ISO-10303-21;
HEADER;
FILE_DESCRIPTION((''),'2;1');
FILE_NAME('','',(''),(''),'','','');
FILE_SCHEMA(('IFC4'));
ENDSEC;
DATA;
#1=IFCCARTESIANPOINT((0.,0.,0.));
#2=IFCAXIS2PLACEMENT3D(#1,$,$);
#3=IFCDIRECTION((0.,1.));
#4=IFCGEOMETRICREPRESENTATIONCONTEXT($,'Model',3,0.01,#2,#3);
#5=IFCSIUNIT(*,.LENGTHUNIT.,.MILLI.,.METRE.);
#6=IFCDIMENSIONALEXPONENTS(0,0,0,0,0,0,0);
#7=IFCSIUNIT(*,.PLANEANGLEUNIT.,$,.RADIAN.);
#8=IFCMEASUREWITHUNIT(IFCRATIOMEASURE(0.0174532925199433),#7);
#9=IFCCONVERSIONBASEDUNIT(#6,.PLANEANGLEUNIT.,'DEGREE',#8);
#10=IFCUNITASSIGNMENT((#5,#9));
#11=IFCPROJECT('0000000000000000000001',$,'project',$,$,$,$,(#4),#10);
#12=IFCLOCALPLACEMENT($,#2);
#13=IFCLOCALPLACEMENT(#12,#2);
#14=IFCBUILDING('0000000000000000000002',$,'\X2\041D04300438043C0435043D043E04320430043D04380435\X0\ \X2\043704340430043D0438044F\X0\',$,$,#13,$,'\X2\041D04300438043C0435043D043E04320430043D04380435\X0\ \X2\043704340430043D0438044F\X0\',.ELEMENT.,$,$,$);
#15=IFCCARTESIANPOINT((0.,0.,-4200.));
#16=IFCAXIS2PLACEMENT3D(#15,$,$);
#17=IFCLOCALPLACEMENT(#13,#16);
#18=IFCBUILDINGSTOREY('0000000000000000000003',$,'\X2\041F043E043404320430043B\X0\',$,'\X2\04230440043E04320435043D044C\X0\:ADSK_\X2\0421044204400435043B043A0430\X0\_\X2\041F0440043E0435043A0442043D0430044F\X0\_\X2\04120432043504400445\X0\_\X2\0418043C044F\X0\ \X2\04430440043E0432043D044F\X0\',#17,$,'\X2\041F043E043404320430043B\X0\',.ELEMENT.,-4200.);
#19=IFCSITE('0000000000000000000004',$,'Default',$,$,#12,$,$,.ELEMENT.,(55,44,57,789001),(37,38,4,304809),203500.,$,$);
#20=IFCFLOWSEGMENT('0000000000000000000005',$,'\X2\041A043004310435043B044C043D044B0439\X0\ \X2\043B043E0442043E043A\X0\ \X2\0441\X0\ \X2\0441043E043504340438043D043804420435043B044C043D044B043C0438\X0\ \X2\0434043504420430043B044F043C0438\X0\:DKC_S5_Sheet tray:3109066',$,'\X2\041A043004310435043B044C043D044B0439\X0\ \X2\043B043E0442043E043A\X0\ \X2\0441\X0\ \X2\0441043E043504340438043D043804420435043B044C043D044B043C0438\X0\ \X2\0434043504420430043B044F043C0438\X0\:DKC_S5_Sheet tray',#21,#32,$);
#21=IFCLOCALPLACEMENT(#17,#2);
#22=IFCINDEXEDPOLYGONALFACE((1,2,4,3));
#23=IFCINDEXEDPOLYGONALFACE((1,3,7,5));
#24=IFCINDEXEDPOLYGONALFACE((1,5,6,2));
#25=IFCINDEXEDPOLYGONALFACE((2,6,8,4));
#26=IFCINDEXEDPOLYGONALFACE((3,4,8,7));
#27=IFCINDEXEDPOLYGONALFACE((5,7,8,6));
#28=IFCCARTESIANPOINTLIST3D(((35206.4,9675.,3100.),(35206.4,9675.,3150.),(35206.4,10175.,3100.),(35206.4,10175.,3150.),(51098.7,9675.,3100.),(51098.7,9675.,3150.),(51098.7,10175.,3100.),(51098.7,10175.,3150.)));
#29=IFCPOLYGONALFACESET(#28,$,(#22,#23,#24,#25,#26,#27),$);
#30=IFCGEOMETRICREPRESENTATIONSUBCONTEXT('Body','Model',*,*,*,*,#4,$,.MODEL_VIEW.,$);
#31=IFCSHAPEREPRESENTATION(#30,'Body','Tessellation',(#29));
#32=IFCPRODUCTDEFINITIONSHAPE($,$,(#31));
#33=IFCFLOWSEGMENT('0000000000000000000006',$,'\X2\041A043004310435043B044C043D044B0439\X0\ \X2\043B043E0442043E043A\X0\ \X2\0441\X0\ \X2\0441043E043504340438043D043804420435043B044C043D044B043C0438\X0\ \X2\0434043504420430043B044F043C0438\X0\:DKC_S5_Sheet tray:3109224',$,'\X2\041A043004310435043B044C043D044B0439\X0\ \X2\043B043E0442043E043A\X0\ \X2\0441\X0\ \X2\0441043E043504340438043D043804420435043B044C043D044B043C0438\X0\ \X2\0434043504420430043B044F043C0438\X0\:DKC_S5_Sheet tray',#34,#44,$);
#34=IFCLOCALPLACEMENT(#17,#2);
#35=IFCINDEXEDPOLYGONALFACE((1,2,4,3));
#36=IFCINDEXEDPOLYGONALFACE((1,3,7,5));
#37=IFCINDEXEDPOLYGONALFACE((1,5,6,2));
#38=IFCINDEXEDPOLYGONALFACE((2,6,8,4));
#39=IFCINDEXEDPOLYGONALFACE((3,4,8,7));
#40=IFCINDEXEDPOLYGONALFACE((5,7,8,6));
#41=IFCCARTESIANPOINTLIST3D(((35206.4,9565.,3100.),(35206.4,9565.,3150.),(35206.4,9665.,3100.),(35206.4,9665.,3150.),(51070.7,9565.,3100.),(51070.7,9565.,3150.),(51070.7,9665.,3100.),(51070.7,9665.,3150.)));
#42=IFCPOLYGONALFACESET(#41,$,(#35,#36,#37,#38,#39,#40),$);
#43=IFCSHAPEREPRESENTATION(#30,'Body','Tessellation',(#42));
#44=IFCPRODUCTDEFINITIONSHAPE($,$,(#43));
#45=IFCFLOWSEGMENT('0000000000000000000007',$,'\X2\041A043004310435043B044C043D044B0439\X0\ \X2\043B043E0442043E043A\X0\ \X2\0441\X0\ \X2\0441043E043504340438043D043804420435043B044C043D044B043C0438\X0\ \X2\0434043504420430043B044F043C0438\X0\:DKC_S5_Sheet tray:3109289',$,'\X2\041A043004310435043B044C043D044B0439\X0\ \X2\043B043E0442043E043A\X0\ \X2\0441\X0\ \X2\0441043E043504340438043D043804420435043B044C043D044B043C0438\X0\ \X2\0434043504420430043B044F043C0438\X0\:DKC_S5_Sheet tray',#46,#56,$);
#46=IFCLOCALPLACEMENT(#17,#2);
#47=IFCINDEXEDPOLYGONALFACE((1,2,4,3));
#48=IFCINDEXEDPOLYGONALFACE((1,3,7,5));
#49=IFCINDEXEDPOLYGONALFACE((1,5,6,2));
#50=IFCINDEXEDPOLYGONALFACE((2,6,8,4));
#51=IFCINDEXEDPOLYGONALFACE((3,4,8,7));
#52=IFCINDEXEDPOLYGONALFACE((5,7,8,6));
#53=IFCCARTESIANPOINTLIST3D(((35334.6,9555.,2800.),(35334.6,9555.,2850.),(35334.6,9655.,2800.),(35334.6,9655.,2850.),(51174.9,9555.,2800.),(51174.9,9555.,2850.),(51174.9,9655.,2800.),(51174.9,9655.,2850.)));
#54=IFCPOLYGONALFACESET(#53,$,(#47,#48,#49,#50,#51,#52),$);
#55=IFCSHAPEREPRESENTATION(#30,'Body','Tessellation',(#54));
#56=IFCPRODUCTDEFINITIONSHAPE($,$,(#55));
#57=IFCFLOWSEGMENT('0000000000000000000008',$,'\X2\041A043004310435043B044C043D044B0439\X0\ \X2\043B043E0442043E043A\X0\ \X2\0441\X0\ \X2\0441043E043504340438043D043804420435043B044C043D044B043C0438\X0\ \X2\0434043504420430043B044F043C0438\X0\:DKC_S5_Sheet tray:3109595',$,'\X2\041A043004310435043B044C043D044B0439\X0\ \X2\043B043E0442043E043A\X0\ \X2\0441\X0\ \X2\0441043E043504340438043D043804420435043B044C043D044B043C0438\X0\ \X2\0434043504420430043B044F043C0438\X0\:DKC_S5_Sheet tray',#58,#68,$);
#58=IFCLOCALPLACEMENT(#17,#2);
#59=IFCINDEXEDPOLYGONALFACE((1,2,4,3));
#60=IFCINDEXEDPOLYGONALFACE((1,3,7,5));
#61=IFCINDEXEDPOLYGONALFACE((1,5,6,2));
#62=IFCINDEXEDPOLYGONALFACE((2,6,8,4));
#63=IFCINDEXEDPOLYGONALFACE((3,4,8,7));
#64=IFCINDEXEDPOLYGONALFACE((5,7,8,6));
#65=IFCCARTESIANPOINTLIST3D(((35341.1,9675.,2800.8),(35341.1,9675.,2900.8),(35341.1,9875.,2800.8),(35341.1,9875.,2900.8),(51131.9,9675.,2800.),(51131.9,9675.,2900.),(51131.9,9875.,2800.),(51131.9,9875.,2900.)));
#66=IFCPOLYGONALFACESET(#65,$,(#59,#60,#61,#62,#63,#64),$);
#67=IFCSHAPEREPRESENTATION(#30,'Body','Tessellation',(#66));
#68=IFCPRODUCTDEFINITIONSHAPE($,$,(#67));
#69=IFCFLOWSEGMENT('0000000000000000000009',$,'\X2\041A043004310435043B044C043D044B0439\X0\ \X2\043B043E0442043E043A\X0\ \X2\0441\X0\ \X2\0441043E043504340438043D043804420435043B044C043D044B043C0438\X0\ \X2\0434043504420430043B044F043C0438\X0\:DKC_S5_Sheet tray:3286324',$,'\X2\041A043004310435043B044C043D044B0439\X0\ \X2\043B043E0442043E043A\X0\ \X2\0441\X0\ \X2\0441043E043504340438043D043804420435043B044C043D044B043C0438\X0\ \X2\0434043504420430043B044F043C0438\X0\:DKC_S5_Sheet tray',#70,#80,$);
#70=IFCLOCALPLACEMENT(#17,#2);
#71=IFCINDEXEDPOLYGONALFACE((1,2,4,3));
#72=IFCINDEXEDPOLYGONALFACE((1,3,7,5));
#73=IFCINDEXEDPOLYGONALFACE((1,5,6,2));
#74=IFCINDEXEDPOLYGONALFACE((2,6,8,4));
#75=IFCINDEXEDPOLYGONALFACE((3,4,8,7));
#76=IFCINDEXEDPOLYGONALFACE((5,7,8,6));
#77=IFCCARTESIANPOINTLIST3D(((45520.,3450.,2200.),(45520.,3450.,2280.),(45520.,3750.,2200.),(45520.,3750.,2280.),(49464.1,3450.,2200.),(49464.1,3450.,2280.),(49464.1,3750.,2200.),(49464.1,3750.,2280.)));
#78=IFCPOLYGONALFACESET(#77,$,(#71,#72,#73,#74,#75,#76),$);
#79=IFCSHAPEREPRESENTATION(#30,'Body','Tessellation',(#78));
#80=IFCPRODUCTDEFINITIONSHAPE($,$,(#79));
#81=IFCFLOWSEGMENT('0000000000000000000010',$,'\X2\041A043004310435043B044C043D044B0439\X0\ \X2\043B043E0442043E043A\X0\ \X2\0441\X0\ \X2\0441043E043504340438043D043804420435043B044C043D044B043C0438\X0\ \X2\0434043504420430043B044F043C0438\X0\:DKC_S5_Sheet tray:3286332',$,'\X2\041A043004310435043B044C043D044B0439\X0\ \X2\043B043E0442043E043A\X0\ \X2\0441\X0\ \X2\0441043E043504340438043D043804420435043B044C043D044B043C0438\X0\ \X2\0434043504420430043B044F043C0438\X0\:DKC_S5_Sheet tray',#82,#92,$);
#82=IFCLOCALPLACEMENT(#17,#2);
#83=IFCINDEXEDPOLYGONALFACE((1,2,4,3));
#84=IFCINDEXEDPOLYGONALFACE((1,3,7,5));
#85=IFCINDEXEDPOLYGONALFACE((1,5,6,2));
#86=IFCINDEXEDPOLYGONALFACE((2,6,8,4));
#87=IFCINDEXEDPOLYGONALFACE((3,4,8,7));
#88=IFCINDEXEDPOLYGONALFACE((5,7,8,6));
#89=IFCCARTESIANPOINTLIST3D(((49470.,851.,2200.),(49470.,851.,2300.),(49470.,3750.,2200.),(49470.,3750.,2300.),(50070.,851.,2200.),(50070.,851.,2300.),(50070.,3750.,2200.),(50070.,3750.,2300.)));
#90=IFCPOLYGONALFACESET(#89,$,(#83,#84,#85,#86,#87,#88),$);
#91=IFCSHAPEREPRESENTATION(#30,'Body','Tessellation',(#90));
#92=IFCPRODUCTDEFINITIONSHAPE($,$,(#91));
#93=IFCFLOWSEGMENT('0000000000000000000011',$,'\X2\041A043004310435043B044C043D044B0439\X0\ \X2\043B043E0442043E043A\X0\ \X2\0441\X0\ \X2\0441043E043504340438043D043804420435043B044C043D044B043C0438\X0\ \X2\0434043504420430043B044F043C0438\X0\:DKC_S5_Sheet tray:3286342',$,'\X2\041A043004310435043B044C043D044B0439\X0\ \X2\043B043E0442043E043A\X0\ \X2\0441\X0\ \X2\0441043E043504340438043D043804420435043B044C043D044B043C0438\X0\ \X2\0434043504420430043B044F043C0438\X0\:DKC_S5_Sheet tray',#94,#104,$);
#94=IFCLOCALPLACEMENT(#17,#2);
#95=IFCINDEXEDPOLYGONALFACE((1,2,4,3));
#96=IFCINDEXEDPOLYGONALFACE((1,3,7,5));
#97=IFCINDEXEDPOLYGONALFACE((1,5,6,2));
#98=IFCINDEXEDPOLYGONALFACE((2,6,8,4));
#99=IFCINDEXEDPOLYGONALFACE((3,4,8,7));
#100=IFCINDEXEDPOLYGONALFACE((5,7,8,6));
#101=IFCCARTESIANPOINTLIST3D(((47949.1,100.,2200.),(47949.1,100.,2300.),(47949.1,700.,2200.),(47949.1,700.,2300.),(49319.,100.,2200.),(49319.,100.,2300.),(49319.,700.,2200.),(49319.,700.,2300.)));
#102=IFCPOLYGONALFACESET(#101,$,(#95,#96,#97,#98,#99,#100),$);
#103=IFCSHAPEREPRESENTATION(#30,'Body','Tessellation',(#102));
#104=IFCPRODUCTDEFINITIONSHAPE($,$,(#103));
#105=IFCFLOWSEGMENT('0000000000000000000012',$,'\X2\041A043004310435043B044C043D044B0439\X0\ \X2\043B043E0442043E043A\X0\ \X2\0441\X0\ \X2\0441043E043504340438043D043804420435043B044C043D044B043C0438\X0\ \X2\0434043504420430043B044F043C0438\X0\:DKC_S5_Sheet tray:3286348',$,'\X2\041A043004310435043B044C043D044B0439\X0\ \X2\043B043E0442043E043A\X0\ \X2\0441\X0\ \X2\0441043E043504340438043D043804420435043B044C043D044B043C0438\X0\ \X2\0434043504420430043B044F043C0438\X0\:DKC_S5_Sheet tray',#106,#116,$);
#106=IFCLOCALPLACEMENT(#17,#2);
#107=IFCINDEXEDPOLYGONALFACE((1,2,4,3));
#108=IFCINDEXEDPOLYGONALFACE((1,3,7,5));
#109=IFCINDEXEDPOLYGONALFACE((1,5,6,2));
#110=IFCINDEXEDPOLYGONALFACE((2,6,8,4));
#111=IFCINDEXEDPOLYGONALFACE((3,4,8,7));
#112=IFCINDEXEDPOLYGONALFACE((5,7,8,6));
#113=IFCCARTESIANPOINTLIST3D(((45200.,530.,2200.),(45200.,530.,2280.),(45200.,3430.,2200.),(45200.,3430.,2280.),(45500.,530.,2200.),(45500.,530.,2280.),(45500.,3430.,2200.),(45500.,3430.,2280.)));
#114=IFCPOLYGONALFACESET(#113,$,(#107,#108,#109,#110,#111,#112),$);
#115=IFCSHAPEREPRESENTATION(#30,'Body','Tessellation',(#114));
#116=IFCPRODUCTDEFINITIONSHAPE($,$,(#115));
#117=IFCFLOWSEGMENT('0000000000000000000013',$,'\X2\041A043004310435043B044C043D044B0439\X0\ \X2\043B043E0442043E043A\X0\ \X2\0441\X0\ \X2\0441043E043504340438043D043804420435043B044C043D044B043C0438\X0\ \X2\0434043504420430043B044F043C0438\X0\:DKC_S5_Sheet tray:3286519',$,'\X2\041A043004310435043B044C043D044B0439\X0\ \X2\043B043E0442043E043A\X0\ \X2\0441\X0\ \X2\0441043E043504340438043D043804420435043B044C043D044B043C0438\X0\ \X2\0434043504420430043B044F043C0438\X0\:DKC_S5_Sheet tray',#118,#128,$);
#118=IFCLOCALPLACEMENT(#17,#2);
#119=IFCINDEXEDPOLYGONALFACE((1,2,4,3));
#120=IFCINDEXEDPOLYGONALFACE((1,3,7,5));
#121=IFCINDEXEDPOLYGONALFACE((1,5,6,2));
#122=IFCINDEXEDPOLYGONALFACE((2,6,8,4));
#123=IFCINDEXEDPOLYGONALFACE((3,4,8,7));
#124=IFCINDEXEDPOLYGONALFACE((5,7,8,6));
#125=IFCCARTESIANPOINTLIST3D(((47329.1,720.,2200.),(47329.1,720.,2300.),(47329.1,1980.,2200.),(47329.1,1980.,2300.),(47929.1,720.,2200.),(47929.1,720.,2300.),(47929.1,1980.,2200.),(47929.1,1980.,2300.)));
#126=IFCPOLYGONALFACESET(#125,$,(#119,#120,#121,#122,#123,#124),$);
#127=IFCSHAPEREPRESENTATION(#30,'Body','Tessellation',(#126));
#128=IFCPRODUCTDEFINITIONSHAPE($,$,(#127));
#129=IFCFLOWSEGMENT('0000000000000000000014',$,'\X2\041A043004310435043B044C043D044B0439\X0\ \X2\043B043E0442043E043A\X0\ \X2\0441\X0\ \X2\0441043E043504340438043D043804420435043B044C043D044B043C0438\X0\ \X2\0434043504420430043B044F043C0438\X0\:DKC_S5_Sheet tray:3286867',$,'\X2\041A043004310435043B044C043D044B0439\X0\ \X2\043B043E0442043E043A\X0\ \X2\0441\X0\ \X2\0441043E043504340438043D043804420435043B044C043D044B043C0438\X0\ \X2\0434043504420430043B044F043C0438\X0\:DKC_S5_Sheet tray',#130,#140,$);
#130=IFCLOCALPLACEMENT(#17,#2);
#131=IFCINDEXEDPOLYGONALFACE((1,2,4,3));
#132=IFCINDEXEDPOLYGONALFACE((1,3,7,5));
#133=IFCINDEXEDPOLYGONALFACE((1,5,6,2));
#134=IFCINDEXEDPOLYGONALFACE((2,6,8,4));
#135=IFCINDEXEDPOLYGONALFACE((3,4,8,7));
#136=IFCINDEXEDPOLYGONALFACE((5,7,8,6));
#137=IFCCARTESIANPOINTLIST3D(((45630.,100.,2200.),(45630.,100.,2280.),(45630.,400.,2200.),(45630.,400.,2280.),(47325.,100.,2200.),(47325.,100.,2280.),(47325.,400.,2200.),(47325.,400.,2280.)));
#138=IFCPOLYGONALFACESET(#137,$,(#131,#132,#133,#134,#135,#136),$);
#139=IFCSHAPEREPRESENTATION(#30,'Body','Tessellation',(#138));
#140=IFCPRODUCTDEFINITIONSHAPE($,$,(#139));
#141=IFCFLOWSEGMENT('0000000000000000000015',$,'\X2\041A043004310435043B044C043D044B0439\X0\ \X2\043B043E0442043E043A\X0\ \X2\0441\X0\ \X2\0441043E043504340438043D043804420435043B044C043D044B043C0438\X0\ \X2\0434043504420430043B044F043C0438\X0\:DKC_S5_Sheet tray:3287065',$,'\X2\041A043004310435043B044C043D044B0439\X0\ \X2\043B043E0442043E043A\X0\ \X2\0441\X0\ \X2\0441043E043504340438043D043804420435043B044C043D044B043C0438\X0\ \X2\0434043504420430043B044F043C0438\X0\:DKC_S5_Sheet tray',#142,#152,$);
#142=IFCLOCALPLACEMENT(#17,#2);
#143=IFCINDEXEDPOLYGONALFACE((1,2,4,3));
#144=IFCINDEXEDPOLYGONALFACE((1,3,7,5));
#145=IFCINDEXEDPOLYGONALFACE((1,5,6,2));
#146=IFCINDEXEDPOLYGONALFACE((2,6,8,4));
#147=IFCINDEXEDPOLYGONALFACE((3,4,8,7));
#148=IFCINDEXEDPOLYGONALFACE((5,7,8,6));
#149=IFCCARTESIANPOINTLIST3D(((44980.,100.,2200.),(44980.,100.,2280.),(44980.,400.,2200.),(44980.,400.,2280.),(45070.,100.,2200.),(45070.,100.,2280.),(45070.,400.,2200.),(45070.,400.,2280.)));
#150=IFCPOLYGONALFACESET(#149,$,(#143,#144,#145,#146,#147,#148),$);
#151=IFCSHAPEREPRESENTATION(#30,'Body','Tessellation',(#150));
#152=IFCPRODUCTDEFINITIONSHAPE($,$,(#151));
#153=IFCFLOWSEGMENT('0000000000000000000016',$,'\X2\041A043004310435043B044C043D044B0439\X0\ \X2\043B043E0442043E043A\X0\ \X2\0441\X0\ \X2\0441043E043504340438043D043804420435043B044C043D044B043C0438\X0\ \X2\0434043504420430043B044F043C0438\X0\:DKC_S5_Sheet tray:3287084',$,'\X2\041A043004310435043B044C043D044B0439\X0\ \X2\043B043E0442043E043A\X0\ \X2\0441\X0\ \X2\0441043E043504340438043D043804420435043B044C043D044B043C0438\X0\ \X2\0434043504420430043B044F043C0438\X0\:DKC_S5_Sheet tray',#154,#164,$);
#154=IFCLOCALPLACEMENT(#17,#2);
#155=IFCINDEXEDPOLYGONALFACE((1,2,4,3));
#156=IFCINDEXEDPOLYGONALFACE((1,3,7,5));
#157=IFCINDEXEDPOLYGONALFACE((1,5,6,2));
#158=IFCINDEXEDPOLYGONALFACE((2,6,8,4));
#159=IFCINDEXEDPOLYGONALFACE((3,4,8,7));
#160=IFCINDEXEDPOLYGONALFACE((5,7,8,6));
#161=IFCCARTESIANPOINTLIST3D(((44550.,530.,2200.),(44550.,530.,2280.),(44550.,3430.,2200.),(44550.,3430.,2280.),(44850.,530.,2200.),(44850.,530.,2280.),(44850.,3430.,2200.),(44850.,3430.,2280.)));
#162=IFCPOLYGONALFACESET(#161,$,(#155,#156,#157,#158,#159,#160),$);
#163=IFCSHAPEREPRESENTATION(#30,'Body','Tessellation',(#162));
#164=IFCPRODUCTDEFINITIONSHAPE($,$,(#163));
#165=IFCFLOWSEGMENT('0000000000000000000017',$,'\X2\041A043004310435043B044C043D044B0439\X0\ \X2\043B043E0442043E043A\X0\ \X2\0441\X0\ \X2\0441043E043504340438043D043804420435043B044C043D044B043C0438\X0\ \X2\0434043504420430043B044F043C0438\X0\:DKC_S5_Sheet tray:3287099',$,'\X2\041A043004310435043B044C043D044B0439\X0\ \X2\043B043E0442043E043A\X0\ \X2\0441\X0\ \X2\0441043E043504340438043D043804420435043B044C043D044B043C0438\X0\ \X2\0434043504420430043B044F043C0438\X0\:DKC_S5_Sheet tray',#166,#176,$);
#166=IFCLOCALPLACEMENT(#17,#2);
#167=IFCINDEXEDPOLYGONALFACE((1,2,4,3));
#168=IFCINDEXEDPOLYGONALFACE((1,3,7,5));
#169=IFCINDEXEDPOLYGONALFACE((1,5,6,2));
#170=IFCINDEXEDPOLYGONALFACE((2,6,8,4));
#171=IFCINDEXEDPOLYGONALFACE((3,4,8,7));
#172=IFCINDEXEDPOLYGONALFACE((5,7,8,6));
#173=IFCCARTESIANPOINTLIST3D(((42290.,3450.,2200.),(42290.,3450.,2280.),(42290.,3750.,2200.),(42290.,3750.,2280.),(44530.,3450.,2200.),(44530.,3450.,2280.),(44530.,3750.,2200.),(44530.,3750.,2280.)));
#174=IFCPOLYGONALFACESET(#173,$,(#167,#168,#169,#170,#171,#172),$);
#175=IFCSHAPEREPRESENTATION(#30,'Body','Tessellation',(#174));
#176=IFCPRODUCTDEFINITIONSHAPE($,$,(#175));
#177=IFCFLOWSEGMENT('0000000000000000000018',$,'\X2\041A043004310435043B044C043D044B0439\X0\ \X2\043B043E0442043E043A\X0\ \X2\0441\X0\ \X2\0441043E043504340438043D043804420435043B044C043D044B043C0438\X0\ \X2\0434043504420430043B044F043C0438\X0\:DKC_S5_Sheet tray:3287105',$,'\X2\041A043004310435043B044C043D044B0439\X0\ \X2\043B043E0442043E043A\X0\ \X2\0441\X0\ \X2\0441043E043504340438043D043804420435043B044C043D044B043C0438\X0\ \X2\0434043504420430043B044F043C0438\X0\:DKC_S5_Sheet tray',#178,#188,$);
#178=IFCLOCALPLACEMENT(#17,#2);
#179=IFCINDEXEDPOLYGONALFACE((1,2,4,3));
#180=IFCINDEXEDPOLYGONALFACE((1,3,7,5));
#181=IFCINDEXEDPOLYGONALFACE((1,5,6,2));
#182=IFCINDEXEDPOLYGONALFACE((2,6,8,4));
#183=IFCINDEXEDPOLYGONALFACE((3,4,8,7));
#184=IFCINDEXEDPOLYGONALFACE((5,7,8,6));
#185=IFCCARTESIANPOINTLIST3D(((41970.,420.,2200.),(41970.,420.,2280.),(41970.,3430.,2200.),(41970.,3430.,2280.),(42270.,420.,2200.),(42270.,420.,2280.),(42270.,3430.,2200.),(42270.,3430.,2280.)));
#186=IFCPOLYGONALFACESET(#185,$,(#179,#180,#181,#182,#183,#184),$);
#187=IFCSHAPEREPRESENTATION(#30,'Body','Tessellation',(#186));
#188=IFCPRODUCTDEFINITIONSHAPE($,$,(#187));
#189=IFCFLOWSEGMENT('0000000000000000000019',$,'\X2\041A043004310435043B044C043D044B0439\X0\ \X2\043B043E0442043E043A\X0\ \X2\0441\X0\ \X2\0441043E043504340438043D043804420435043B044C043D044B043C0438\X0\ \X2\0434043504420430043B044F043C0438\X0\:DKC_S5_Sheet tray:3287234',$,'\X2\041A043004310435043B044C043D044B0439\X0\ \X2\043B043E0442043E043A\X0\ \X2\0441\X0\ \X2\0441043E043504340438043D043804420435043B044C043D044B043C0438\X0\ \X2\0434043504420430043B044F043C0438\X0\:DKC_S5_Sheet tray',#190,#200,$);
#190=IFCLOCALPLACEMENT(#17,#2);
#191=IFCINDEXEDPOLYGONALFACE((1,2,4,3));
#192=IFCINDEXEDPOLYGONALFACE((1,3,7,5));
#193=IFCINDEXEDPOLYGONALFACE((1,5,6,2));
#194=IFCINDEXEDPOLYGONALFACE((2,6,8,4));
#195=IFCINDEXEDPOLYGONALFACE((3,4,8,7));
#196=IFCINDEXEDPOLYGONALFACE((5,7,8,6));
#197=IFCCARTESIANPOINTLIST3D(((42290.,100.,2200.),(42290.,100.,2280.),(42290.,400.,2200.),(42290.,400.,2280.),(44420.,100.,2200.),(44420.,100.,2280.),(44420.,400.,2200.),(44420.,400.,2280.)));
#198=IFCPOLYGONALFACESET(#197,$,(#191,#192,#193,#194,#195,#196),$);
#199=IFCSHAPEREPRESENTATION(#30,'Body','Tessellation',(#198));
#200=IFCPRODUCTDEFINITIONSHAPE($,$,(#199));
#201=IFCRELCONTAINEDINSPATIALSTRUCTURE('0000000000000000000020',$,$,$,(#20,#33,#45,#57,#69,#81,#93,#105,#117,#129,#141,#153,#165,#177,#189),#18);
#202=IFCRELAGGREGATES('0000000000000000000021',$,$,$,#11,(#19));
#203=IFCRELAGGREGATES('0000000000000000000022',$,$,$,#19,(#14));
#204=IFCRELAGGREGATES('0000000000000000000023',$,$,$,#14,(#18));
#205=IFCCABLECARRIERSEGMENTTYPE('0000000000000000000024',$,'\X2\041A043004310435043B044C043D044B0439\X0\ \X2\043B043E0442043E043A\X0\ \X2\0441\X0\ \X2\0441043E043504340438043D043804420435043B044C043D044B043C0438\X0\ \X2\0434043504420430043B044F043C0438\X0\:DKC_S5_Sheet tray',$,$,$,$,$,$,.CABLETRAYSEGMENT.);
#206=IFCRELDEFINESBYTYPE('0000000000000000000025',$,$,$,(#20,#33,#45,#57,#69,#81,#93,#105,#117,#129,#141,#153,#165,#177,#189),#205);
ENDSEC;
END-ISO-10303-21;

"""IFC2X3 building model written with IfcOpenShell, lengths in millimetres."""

from ifc_helpers import new_model, entity, si_unit, converted_unit, direction, frame, frame_2d, origin, origin_2d_with_axis, place, context, subcontext, project, spatial, rectangle, extrude, type_object, element, save


model = new_model("IFC2X3")

# Units and contexts
model_context = context("Model", 3, precision=0.01, world=origin(), true_north=direction((0.0, 1.0)))
body_context = subcontext(model_context, "Body", "Model", "MODEL_VIEW")
ifc_project = project(units=[si_unit("LENGTHUNIT", "METRE", prefix="MILLI"), converted_unit("PLANEANGLEUNIT", "DEGREE", entity("IfcRatioMeasure", 0.0174532925199433), si_unit("PLANEANGLEUNIT", "RADIAN"), dimensions=[0, 0, 0, 0, 0, 0, 0])], contexts=[model_context])

# Site, building, storey
site_placement = place(None, frame((0.0, 0.0, 0.0)))
site = spatial("IfcSite", under=ifc_project, at=site_placement, Name="Default", CompositionType="ELEMENT", RefLatitude=(55, 44, 57, 789001), RefLongitude=(37, 38, 4, 304809), RefElevation=203500.0)
building_placement = place(site_placement, origin())
building = spatial("IfcBuilding", under=site, at=building_placement, Name="Наименование здания", LongName="Наименование здания", CompositionType="ELEMENT")
storey_placement = place(building_placement, frame((0.0, 0.0, -4200.0)))
storey = spatial("IfcBuildingStorey", under=building, at=storey_placement, Name="Подвал", ObjectType="Уровень:ADSK_Стрелка_Проектная_Вверх_Имя уровня", LongName="Подвал", CompositionType="ELEMENT", Elevation=-4200.0)

# Flow segments
cable_carrier_segment_type_1 = type_object("IfcCableCarrierSegmentType", Name="Кабельный лоток с соединительными деталями:DKC_S5_Sheet tray", PredefinedType="CABLETRAYSEGMENT")
flow_segment_1_placement = place(storey_placement, frame((35206.4, 9675.0, 3100.0)))
element("IfcFlowSegment", 1, at=flow_segment_1_placement, inside=storey, type_object=cable_carrier_segment_type_1, Name="Кабельный лоток с соединительными деталями:DKC_S5_Sheet tray:3109066", ObjectType="Кабельный лоток с соединительными деталями:DKC_S5_Sheet tray", context=body_context, shape_type="SweptSolid", body=[
    extrude(rectangle(XDim=15892.3, YDim=500.0, at=frame_2d((0.0, 0.0), x_axis=(1.0, 0.0))), frame((7946.1, 250.0, 0.0), z_axis=(0.0, 0.0, 1.0), x_axis=(-1.0, 0.0, 0.0)), (0.0, 0.0, 1.0), 50.0),
])
flow_segment_2_placement = place(storey_placement, frame((35206.4, 9565.0, 3100.0)))
element("IfcFlowSegment", 2, at=flow_segment_2_placement, inside=storey, type_object=cable_carrier_segment_type_1, Name="Кабельный лоток с соединительными деталями:DKC_S5_Sheet tray:3109224", ObjectType="Кабельный лоток с соединительными деталями:DKC_S5_Sheet tray", context=body_context, shape_type="SweptSolid", body=[
    extrude(rectangle(XDim=15864.3, YDim=100.0, at=frame_2d((0.0, 0.0), x_axis=(1.0, 0.0))), frame((7932.2, 50.0, 0.0), z_axis=(0.0, 0.0, 1.0), x_axis=(-1.0, 0.0, 0.0)), (0.0, 0.0, 1.0), 50.0),
])
flow_segment_3_placement = place(storey_placement, frame((35334.6, 9555.0, 2800.0)))
element("IfcFlowSegment", 3, at=flow_segment_3_placement, inside=storey, type_object=cable_carrier_segment_type_1, Name="Кабельный лоток с соединительными деталями:DKC_S5_Sheet tray:3109289", ObjectType="Кабельный лоток с соединительными деталями:DKC_S5_Sheet tray", context=body_context, shape_type="SweptSolid", body=[
    extrude(rectangle(XDim=15840.3, YDim=100.0, at=frame_2d((0.0, 0.0), x_axis=(1.0, 0.0))), frame((7920.1, 50.0, 0.0)), (0.0, 0.0, 1.0), 50.0),
])
flow_segment_4_placement = place(storey_placement, frame((35341.1, 9675.0, 2800.0)))
element("IfcFlowSegment", 4, at=flow_segment_4_placement, inside=storey, type_object=cable_carrier_segment_type_1, Name="Кабельный лоток с соединительными деталями:DKC_S5_Sheet tray:3109595", ObjectType="Кабельный лоток с соединительными деталями:DKC_S5_Sheet tray", context=body_context, shape_type="SweptSolid", body=[
    extrude(rectangle(XDim=200.0, YDim=15790.8, at=frame_2d((0.0, 0.0), x_axis=(0.0, 1.0))), frame((7895.4, 100.0, 0.4), z_axis=(0.00005, 0.000146, 1.0), x_axis=(1.0, 0.0, -0.00005)), (0.0, 0.0, 1.0), 100.0),
])
flow_segment_5_placement = place(storey_placement, frame((45520.0, 3450.0, 2200.0)))
element("IfcFlowSegment", 5, at=flow_segment_5_placement, inside=storey, type_object=cable_carrier_segment_type_1, Name="Кабельный лоток с соединительными деталями:DKC_S5_Sheet tray:3286324", ObjectType="Кабельный лоток с соединительными деталями:DKC_S5_Sheet tray", context=body_context, shape_type="SweptSolid", body=[
    extrude(rectangle(XDim=3944.1, YDim=300.0, at=frame_2d((0.0, 0.0), x_axis=(1.0, 0.0))), frame((1972.0, 150.0, 0.0)), (0.0, 0.0, 1.0), 80.0),
])
flow_segment_6_placement = place(storey_placement, frame((49470.0, 851.0, 2200.0)))
element("IfcFlowSegment", 6, at=flow_segment_6_placement, inside=storey, type_object=cable_carrier_segment_type_1, Name="Кабельный лоток с соединительными деталями:DKC_S5_Sheet tray:3286332", ObjectType="Кабельный лоток с соединительными деталями:DKC_S5_Sheet tray", context=body_context, shape_type="SweptSolid", body=[
    extrude(rectangle(XDim=2899.0, YDim=600.0, at=frame_2d((0.0, 0.0), x_axis=(1.0, 0.0))), frame((300.0, 1449.5, 0.0), z_axis=(0.0, 0.0, 1.0), x_axis=(0.0, 1.0, 0.0)), (0.0, 0.0, 1.0), 100.0),
])
flow_segment_7_placement = place(storey_placement, frame((47949.1, 100.0, 2200.0)))
element("IfcFlowSegment", 7, at=flow_segment_7_placement, inside=storey, type_object=cable_carrier_segment_type_1, Name="Кабельный лоток с соединительными деталями:DKC_S5_Sheet tray:3286342", ObjectType="Кабельный лоток с соединительными деталями:DKC_S5_Sheet tray", context=body_context, shape_type="SweptSolid", body=[
    extrude(rectangle(XDim=1369.9, YDim=600.0, at=frame_2d((0.0, 0.0), x_axis=(1.0, 0.0))), frame((685.0, 300.0, 0.0), z_axis=(0.0, 0.0, 1.0), x_axis=(-1.0, 0.0, 0.0)), (0.0, 0.0, 1.0), 100.0),
])
flow_segment_8_placement = place(storey_placement, frame((45200.0, 530.0, 2200.0)))
element("IfcFlowSegment", 8, at=flow_segment_8_placement, inside=storey, type_object=cable_carrier_segment_type_1, Name="Кабельный лоток с соединительными деталями:DKC_S5_Sheet tray:3286348", ObjectType="Кабельный лоток с соединительными деталями:DKC_S5_Sheet tray", context=body_context, shape_type="SweptSolid", body=[
    extrude(rectangle(XDim=2900.0, YDim=300.0, at=frame_2d((0.0, 0.0), x_axis=(1.0, 0.0))), frame((150.0, 1450.0, 0.0), z_axis=(0.0, 0.0, 1.0), x_axis=(0.0, -1.0, 0.0)), (0.0, 0.0, 1.0), 80.0),
])
flow_segment_9_placement = place(storey_placement, frame((47329.1, 720.0, 2200.0)))
element("IfcFlowSegment", 9, at=flow_segment_9_placement, inside=storey, type_object=cable_carrier_segment_type_1, Name="Кабельный лоток с соединительными деталями:DKC_S5_Sheet tray:3286519", ObjectType="Кабельный лоток с соединительными деталями:DKC_S5_Sheet tray", context=body_context, shape_type="SweptSolid", body=[
    extrude(rectangle(XDim=1260.0, YDim=600.0, at=frame_2d((0.0, 0.0), x_axis=(1.0, 0.0))), frame((300.0, 630.0, 0.0), z_axis=(0.0, 0.0, 1.0), x_axis=(0.0, 1.0, 0.0)), (0.0, 0.0, 1.0), 100.0),
])
flow_segment_10_placement = place(storey_placement, frame((45630.0, 100.0, 2200.0)))
element("IfcFlowSegment", 10, at=flow_segment_10_placement, inside=storey, type_object=cable_carrier_segment_type_1, Name="Кабельный лоток с соединительными деталями:DKC_S5_Sheet tray:3286867", ObjectType="Кабельный лоток с соединительными деталями:DKC_S5_Sheet tray", context=body_context, shape_type="SweptSolid", body=[
    extrude(rectangle(XDim=1695.0, YDim=300.0, at=origin_2d_with_axis()), frame((847.5, 150.0, 0.0)), (0.0, 0.0, 1.0), 80.0),
])
flow_segment_11_placement = place(storey_placement, frame((44980.0, 100.0, 2200.0)))
element("IfcFlowSegment", 11, at=flow_segment_11_placement, inside=storey, type_object=cable_carrier_segment_type_1, Name="Кабельный лоток с соединительными деталями:DKC_S5_Sheet tray:3287065", ObjectType="Кабельный лоток с соединительными деталями:DKC_S5_Sheet tray", context=body_context, shape_type="SweptSolid", body=[
    extrude(rectangle(XDim=90.0, YDim=300.0, at=frame_2d((0.0, 0.0), x_axis=(1.0, 0.0))), frame((45.0, 150.0, 0.0), z_axis=(0.0, 0.0, 1.0), x_axis=(-1.0, 0.0, 0.0)), (0.0, 0.0, 1.0), 80.0),
])
flow_segment_12_placement = place(storey_placement, frame((44550.0, 530.0, 2200.0)))
element("IfcFlowSegment", 12, at=flow_segment_12_placement, inside=storey, type_object=cable_carrier_segment_type_1, Name="Кабельный лоток с соединительными деталями:DKC_S5_Sheet tray:3287084", ObjectType="Кабельный лоток с соединительными деталями:DKC_S5_Sheet tray", context=body_context, shape_type="SweptSolid", body=[
    extrude(rectangle(XDim=2900.0, YDim=300.0, at=frame_2d((0.0, 0.0), x_axis=(1.0, 0.0))), frame((150.0, 1450.0, 0.0), z_axis=(0.0, 0.0, 1.0), x_axis=(0.0, 1.0, 0.0)), (0.0, 0.0, 1.0), 80.0),
])
flow_segment_13_placement = place(storey_placement, frame((42290.0, 3450.0, 2200.0)))
element("IfcFlowSegment", 13, at=flow_segment_13_placement, inside=storey, type_object=cable_carrier_segment_type_1, Name="Кабельный лоток с соединительными деталями:DKC_S5_Sheet tray:3287099", ObjectType="Кабельный лоток с соединительными деталями:DKC_S5_Sheet tray", context=body_context, shape_type="SweptSolid", body=[
    extrude(rectangle(XDim=2240.0, YDim=300.0, at=origin_2d_with_axis()), frame((1120.0, 150.0, 0.0), z_axis=(0.0, 0.0, 1.0), x_axis=(-1.0, 0.0, 0.0)), (0.0, 0.0, 1.0), 80.0),
])
flow_segment_14_placement = place(storey_placement, frame((41970.0, 420.0, 2200.0)))
element("IfcFlowSegment", 14, at=flow_segment_14_placement, inside=storey, type_object=cable_carrier_segment_type_1, Name="Кабельный лоток с соединительными деталями:DKC_S5_Sheet tray:3287105", ObjectType="Кабельный лоток с соединительными деталями:DKC_S5_Sheet tray", context=body_context, shape_type="SweptSolid", body=[
    extrude(rectangle(XDim=3010.0, YDim=300.0, at=origin_2d_with_axis()), frame((150.0, 1505.0, 0.0), z_axis=(0.0, 0.0, 1.0), x_axis=(0.0, -1.0, 0.0)), (0.0, 0.0, 1.0), 80.0),
])
flow_segment_15_placement = place(storey_placement, frame((42290.0, 100.0, 2200.0)))
element("IfcFlowSegment", 15, at=flow_segment_15_placement, inside=storey, type_object=cable_carrier_segment_type_1, Name="Кабельный лоток с соединительными деталями:DKC_S5_Sheet tray:3287234", ObjectType="Кабельный лоток с соединительными деталями:DKC_S5_Sheet tray", context=body_context, shape_type="SweptSolid", body=[
    extrude(rectangle(XDim=2130.0, YDim=300.0, at=frame_2d((0.0, 0.0), x_axis=(1.0, 0.0))), frame((1065.0, 150.0, 0.0)), (0.0, 0.0, 1.0), 80.0),
])

save(model, "model.ifc")
